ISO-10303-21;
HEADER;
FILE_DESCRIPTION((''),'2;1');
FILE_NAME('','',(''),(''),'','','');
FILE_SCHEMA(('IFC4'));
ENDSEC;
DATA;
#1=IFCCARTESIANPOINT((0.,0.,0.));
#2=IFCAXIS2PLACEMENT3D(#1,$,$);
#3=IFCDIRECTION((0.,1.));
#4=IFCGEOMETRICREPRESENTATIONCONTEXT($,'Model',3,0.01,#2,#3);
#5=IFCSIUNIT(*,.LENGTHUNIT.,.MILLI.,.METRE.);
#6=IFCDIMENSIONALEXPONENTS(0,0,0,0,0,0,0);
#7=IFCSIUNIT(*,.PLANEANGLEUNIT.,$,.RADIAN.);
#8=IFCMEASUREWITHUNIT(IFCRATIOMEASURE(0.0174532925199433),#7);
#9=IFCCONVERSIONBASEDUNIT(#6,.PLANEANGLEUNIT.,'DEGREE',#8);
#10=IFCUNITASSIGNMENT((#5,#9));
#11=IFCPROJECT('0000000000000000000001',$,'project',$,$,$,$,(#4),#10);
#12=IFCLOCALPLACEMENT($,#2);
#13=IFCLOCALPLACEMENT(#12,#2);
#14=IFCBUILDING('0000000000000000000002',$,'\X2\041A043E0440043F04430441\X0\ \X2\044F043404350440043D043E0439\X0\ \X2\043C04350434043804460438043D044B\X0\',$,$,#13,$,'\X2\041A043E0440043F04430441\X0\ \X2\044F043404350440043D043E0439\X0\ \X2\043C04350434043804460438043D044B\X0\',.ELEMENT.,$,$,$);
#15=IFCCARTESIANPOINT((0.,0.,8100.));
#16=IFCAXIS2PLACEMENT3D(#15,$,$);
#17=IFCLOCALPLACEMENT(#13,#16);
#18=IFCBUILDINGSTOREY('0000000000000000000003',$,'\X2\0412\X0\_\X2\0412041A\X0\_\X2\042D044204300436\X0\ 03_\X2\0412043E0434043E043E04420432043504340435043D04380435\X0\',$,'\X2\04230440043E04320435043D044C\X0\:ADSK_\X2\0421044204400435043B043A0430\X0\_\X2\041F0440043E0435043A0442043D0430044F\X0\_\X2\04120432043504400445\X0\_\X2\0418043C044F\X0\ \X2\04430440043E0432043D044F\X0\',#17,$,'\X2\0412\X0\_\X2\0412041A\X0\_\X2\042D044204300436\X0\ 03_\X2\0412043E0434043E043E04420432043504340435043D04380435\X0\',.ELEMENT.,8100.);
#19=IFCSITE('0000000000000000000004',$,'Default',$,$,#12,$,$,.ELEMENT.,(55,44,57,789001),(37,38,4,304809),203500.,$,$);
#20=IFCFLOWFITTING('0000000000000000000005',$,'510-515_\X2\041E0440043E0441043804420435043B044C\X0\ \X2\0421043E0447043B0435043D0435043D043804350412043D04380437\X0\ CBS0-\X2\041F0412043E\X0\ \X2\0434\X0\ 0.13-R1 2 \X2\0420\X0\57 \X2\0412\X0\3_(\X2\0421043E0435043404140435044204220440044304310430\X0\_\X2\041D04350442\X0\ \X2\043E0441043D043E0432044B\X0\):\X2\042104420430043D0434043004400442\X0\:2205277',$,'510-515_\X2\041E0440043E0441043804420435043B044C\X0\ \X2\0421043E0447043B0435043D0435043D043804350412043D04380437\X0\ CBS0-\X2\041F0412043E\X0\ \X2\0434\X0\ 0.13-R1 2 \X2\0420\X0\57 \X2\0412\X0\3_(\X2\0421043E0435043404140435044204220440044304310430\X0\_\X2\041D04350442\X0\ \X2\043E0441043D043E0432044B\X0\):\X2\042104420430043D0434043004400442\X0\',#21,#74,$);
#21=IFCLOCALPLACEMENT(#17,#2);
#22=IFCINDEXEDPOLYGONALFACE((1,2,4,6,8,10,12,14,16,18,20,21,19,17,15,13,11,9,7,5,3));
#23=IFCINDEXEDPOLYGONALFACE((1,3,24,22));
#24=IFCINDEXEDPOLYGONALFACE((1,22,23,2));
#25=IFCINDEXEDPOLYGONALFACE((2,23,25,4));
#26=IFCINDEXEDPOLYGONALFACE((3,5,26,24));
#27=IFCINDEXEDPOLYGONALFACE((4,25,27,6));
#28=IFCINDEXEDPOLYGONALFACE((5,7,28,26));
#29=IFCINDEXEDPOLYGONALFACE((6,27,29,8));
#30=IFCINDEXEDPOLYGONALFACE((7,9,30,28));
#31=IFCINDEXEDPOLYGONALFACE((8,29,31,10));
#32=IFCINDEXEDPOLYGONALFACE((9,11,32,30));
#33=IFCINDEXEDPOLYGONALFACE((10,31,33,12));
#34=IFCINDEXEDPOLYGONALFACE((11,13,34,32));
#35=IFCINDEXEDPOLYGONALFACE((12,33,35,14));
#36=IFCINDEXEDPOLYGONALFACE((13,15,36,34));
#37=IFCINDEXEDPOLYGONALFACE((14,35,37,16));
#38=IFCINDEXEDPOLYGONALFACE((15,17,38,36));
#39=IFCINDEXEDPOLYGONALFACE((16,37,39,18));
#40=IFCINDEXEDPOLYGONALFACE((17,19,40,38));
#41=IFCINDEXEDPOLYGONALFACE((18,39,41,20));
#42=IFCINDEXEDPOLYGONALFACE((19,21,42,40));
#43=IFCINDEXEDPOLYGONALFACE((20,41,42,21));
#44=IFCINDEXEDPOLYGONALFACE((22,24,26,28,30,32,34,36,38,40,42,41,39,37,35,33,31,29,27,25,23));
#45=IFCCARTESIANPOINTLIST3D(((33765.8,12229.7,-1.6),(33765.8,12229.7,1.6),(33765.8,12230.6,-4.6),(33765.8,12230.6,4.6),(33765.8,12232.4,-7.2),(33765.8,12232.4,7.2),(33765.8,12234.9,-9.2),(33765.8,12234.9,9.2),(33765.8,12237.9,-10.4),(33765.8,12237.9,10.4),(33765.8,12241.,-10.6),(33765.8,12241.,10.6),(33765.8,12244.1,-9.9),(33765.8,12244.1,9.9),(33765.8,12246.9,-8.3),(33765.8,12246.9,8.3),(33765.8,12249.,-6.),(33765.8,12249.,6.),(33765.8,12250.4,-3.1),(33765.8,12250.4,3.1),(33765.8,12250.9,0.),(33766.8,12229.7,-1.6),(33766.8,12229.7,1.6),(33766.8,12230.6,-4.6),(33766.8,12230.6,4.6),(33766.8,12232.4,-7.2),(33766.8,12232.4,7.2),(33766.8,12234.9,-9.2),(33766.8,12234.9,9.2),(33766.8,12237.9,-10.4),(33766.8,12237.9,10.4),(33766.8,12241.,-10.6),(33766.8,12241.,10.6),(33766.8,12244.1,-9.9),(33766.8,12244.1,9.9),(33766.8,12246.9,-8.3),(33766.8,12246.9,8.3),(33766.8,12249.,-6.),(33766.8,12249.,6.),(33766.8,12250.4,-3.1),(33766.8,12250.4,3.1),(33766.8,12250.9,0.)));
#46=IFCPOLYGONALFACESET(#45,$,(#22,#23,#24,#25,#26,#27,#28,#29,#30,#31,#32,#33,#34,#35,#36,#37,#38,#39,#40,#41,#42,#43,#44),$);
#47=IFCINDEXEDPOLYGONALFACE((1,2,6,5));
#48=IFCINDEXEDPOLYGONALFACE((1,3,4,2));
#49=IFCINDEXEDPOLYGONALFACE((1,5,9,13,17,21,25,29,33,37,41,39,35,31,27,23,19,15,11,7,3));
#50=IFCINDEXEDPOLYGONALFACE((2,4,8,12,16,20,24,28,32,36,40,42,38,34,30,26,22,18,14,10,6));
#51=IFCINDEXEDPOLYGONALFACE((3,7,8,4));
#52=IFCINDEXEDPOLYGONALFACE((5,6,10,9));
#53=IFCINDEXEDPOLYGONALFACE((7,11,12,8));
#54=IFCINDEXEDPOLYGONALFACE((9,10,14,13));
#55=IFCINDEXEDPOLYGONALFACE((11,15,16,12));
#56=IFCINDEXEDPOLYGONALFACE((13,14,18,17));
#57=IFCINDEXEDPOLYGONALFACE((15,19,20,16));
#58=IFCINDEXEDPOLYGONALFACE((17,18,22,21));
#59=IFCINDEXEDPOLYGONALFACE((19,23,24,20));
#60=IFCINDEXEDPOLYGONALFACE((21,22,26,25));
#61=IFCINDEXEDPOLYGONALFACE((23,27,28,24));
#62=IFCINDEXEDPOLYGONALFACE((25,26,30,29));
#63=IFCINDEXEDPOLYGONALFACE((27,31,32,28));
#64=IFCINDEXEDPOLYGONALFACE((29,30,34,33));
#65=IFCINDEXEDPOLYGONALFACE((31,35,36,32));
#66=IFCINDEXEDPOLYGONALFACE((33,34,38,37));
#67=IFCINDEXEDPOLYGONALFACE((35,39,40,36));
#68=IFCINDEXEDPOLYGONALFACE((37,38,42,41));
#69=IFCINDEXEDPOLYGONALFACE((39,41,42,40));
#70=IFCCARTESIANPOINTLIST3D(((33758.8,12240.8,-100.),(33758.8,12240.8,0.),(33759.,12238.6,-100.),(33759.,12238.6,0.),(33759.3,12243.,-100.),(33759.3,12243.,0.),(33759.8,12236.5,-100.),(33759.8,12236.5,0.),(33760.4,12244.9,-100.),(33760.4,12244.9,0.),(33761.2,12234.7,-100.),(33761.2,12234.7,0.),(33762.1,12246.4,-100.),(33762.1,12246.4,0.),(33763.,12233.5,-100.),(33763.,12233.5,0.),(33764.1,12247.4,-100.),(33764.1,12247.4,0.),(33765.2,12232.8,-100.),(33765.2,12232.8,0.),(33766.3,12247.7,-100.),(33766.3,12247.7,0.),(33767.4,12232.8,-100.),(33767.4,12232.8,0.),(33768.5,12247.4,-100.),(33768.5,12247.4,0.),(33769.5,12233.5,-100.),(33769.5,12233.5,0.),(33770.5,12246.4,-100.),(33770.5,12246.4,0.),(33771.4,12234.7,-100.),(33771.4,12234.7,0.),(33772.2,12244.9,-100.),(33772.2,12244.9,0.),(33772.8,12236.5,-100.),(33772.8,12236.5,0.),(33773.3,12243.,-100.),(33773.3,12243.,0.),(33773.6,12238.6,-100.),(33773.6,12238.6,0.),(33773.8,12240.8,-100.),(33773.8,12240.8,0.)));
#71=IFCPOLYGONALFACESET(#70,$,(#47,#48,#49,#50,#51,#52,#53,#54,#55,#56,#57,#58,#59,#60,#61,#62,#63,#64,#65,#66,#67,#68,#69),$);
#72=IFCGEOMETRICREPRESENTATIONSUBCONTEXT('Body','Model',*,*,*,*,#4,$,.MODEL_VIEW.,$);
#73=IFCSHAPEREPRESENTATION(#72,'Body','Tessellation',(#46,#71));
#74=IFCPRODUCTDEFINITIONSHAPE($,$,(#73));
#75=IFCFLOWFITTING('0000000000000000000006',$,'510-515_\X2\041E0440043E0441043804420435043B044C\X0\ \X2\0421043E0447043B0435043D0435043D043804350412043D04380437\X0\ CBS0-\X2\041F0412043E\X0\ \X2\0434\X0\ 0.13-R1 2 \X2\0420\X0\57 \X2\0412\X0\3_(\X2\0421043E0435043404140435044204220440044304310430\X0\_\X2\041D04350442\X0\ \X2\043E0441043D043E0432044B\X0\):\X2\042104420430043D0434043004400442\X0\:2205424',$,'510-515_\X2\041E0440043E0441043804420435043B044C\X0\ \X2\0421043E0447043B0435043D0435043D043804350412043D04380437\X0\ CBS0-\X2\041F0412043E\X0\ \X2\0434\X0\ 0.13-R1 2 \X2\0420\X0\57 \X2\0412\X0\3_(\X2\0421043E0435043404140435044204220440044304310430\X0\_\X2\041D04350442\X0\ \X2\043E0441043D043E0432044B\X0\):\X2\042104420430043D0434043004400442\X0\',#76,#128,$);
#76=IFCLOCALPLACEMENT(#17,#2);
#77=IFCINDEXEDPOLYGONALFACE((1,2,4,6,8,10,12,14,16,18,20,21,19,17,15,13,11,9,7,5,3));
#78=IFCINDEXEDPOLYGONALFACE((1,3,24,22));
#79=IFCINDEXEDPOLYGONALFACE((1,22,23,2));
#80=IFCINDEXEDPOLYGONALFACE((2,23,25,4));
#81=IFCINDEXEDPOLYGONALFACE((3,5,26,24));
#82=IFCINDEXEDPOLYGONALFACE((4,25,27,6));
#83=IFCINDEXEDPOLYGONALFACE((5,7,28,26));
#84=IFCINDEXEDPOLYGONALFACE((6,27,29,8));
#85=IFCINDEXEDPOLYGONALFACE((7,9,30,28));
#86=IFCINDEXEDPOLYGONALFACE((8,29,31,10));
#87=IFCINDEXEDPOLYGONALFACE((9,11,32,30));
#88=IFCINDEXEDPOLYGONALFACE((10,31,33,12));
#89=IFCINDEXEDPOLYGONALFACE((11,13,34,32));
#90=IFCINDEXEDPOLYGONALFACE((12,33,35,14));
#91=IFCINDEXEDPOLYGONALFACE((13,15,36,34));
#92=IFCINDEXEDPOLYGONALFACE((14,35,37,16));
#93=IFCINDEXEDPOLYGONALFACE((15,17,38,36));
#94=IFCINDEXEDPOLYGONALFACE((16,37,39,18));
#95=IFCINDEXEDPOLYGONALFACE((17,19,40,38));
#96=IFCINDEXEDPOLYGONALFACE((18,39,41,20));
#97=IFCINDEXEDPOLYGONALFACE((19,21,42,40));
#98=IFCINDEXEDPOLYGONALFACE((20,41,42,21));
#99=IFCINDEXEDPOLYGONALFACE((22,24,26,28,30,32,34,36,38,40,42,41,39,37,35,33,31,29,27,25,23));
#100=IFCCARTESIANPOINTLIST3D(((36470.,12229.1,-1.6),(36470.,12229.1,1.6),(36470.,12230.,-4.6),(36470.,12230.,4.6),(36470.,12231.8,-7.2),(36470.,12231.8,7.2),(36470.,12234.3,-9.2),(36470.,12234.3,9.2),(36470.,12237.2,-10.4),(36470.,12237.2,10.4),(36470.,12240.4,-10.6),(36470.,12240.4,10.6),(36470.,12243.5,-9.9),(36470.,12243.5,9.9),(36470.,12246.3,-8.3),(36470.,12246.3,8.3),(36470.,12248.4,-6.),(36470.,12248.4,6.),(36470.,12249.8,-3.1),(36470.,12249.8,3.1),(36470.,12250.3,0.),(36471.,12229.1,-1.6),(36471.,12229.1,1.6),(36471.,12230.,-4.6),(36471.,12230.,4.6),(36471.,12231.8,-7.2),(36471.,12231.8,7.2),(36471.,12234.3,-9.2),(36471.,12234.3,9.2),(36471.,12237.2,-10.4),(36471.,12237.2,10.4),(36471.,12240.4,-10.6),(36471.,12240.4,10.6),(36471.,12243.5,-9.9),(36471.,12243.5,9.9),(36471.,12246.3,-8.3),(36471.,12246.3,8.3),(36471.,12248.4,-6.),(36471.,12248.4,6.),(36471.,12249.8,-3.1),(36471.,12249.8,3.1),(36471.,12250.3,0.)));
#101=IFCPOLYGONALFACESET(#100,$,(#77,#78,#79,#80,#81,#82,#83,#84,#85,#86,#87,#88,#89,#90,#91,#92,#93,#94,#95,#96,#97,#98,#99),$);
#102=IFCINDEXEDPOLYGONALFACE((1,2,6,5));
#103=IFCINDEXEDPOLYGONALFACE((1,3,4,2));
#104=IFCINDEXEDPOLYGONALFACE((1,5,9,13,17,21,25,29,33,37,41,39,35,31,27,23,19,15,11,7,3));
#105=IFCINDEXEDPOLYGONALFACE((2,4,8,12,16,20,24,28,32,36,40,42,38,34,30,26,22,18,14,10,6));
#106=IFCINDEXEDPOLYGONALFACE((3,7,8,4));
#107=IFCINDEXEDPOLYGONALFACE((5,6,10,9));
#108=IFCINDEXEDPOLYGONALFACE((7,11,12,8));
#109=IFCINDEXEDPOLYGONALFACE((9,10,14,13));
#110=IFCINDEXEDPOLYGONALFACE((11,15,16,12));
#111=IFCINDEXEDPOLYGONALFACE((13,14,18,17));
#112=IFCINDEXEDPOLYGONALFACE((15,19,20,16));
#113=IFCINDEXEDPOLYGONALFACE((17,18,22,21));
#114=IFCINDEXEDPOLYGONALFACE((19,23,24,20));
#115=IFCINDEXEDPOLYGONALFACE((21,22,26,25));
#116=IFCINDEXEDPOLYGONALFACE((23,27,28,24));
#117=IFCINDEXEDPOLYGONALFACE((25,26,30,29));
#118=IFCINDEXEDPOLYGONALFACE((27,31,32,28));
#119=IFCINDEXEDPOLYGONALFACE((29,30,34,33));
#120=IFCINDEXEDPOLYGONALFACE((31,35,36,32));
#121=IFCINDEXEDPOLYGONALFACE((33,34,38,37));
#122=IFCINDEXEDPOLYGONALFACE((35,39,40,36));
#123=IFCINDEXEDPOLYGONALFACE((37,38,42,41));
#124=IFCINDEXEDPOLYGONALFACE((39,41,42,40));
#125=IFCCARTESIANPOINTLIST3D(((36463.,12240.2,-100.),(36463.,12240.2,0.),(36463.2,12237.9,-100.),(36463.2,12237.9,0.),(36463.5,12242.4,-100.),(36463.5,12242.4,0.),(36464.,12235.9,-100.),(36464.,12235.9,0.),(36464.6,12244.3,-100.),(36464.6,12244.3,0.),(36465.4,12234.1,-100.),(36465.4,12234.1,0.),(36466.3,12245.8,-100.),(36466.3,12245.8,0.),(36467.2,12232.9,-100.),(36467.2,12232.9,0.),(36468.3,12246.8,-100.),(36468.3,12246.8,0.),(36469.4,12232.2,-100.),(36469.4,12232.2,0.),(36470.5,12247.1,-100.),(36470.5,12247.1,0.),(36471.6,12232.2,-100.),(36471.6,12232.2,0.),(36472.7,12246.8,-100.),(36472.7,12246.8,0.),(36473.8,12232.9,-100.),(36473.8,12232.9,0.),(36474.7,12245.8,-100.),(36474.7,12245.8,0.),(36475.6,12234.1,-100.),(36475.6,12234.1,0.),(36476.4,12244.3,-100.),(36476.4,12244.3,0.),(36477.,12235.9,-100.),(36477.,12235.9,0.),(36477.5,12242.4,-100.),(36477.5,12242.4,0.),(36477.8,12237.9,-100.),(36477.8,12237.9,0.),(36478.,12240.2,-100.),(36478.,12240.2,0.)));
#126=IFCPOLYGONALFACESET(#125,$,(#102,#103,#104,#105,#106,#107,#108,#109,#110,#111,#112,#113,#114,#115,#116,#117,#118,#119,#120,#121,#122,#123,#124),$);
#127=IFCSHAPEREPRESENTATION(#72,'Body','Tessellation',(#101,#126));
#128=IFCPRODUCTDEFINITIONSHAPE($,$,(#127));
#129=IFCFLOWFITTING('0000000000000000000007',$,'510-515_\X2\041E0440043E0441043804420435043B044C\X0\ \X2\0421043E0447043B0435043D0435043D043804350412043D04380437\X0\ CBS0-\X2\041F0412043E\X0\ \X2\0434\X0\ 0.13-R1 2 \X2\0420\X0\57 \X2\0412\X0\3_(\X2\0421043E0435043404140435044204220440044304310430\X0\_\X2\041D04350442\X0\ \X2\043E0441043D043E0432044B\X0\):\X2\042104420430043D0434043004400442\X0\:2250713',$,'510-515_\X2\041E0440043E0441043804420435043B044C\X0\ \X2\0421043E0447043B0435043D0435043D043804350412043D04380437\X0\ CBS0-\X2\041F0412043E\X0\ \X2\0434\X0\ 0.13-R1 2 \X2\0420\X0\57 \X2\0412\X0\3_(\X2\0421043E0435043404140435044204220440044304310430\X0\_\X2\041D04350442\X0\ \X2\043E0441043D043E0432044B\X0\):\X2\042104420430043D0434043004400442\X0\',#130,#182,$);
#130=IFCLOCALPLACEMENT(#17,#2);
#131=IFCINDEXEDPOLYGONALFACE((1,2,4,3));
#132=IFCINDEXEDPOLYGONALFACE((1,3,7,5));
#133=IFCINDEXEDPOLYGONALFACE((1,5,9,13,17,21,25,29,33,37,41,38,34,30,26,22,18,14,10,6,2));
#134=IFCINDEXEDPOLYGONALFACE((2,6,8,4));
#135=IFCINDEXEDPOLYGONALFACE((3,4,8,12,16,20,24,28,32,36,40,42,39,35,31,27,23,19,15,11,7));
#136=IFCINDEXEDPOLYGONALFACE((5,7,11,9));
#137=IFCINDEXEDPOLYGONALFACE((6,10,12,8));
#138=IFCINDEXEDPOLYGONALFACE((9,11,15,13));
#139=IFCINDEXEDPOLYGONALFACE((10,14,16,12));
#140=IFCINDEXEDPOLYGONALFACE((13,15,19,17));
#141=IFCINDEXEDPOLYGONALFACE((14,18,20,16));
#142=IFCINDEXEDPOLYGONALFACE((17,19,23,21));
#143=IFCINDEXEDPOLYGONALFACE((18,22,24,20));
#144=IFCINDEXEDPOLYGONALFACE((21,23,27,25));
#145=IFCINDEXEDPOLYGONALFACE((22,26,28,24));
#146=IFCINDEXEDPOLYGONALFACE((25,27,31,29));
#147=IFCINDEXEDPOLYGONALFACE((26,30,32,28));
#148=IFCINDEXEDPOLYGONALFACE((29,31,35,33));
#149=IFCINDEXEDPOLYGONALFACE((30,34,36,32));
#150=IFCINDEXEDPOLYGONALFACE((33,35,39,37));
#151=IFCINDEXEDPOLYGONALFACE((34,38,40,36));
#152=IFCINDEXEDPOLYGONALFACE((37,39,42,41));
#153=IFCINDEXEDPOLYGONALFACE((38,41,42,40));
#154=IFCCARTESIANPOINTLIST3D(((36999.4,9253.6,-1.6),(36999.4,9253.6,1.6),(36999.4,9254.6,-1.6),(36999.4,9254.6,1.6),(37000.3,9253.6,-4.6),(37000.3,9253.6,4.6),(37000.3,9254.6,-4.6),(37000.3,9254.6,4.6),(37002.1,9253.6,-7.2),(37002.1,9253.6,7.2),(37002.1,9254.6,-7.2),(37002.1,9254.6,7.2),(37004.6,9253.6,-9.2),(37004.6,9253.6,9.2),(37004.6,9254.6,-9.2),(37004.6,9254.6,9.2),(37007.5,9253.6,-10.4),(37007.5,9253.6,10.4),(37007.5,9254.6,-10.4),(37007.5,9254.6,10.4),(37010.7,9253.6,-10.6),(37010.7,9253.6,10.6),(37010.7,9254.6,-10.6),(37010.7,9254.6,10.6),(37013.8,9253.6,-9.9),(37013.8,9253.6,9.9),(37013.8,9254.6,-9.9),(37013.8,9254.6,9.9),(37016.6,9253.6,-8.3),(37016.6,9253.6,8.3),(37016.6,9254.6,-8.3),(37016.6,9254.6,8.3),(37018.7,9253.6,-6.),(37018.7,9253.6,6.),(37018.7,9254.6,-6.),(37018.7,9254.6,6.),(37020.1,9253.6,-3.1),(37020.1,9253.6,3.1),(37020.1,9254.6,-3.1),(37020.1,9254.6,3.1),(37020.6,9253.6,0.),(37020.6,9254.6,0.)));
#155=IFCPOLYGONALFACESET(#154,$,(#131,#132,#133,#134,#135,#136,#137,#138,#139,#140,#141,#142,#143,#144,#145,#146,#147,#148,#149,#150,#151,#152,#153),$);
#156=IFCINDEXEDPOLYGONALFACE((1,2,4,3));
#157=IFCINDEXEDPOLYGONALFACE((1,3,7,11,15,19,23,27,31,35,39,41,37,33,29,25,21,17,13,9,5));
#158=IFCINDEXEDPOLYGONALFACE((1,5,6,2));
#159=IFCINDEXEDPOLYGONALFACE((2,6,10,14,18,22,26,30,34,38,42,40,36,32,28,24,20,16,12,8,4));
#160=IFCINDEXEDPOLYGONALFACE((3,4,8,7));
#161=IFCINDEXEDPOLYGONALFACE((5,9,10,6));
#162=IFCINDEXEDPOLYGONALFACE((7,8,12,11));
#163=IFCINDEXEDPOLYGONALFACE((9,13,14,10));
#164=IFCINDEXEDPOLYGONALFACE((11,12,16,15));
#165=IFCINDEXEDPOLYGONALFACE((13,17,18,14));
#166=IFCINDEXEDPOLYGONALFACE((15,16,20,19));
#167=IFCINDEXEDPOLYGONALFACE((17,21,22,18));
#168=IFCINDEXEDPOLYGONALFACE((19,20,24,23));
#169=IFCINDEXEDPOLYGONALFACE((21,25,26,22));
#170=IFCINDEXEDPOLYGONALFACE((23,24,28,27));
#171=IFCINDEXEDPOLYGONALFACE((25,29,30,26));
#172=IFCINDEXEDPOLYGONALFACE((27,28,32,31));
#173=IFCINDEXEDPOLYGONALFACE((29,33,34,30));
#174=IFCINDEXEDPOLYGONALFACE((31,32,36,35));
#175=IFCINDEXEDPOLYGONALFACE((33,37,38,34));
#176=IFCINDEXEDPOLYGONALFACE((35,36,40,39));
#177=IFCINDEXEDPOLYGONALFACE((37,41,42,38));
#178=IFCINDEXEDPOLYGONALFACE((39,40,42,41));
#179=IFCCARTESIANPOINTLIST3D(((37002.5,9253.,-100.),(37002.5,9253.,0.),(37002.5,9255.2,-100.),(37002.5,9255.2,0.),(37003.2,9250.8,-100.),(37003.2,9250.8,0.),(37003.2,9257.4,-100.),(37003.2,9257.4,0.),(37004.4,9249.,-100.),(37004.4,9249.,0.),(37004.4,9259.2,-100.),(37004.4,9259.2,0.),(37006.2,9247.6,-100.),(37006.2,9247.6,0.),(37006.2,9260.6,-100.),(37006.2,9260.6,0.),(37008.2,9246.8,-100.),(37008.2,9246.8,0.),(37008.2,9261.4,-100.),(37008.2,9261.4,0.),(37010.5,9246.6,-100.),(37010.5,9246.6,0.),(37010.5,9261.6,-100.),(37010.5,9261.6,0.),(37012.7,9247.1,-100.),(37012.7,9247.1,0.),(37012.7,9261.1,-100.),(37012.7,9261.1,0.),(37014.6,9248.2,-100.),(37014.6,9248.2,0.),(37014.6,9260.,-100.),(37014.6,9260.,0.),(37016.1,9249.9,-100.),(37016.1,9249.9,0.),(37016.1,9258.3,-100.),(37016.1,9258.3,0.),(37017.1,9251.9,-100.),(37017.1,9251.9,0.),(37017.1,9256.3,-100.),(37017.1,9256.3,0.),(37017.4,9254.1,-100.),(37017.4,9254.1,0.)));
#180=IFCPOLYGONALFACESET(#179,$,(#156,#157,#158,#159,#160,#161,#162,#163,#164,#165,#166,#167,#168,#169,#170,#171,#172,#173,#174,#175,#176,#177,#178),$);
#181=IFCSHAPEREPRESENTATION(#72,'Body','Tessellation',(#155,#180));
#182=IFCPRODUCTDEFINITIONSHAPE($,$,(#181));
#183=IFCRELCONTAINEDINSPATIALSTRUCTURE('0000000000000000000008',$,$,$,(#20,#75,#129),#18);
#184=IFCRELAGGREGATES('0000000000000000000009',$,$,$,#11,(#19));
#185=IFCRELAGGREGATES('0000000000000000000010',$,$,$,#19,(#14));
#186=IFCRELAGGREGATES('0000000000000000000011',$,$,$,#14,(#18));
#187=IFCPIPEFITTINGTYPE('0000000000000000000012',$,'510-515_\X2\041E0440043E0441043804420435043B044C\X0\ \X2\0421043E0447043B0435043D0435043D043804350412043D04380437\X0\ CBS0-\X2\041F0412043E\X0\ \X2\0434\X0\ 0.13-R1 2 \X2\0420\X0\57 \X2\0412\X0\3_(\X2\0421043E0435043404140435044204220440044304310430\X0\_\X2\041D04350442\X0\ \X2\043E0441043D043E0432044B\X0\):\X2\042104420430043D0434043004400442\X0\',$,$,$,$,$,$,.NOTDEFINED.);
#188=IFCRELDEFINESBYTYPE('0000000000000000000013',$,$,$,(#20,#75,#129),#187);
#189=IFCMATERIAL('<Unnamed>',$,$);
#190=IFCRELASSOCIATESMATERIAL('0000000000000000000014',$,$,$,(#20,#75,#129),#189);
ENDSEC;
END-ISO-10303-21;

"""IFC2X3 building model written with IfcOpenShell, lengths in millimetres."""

from ifc_helpers import new_model, entity, si_unit, converted_unit, direction, frame, origin, origin_2d_with_axis, place, context, subcontext, project, spatial, circle, extrude, source, transform, mapped, material, type_object, type_shapes, element, save


model = new_model("IFC2X3")

# Units and contexts
model_context = context("Model", 3, precision=0.01, world=origin(), true_north=direction((0.0, 1.0)))
body_context = subcontext(model_context, "Body", "Model", "MODEL_VIEW")
ifc_project = project(units=[si_unit("LENGTHUNIT", "METRE", prefix="MILLI"), converted_unit("PLANEANGLEUNIT", "DEGREE", entity("IfcRatioMeasure", 0.0174532925199433), si_unit("PLANEANGLEUNIT", "RADIAN"), dimensions=[0, 0, 0, 0, 0, 0, 0])], contexts=[model_context])

# Site, building, storey
site_placement = place(None, origin())
site = spatial("IfcSite", under=ifc_project, at=site_placement, Name="Default", CompositionType="ELEMENT", RefLatitude=(55, 44, 57, 789001), RefLongitude=(37, 38, 4, 304809), RefElevation=203500.0)
building_placement = place(site_placement, origin())
building = spatial("IfcBuilding", under=site, at=building_placement, Name="Корпус ядерной медицины", LongName="Корпус ядерной медицины", CompositionType="ELEMENT")
storey_placement = place(building_placement, frame((0.0, 0.0, 8100.0)))
storey = spatial("IfcBuildingStorey", under=building, at=storey_placement, Name="В_ВК_Этаж 03_Водоотведение", ObjectType="Уровень:ADSK_Стрелка_Проектная_Вверх_Имя уровня", LongName="В_ВК_Этаж 03_Водоотведение", CompositionType="ELEMENT", Elevation=8100.0)

# Flow fittings
ifc_material = material(Name="<Unnamed>")
pipe_fitting_type_1 = type_object("IfcPipeFittingType", Name="510-515_Ороситель СочленениеВниз CBS0-ПВо д 0.13-R1 2 Р57 В3_(СоедДетТруба_Нет основы):Стандарт", PredefinedType="NOTDEFINED")
shared_shape_1 = source(origin(), body_context, "Body", "SweptSolid", [
    extrude(circle(Radius=10.7, at=origin_2d_with_axis()), frame((-0.5, 0.0, 0.0), z_axis=(1.0, 0.0, 0.0), x_axis=(0.0, 1.0, 0.0)), (0.0, 0.0, 1.0), 1.0),
    extrude(circle(Radius=7.5, at=origin_2d_with_axis()), frame((0.0, 0.0, -100.0), z_axis=(0.0, 0.0, 1.0), x_axis=(0.0, 1.0, 0.0)), (0.0, 0.0, 1.0), 100.0),
])
type_shapes(pipe_fitting_type_1, [shared_shape_1])
for number, where, name in (
    (1, (33766.3, 12240.2, 0.0), "510-515_Ороситель СочленениеВниз CBS0-ПВо д 0.13-R1 2 Р57 В3_(СоедДетТруба_Нет основы):Стандарт:2205277"),
    (2, (36470.5, 12239.6, 0.0), "510-515_Ороситель СочленениеВниз CBS0-ПВо д 0.13-R1 2 Р57 В3_(СоедДетТруба_Нет основы):Стандарт:2205424"),
):
    element("IfcFlowFitting", number, at=place(storey_placement, frame(where)), inside=storey, type_object=pipe_fitting_type_1, material=ifc_material, Name=name, ObjectType="510-515_Ороситель СочленениеВниз CBS0-ПВо д 0.13-R1 2 Р57 В3_(СоедДетТруба_Нет основы):Стандарт", context=body_context, shape_type="MappedRepresentation", body=[
        mapped(shared_shape_1, transform((0.0, 0.0, 0.0), scale=1.0)),
    ])
for number, where, z_axis, x_axis, name in (
    (3, (37009.9, 9254.1, 0.0), (0.0, 0.0, 1.0), (0.0, -1.0, 0.0), "510-515_Ороситель СочленениеВниз CBS0-ПВо д 0.13-R1 2 Р57 В3_(СоедДетТруба_Нет основы):Стандарт:2250713"),
):
    element("IfcFlowFitting", number, at=place(storey_placement, frame(where, z_axis=z_axis, x_axis=x_axis)), inside=storey, type_object=pipe_fitting_type_1, material=ifc_material, Name=name, ObjectType="510-515_Ороситель СочленениеВниз CBS0-ПВо д 0.13-R1 2 Р57 В3_(СоедДетТруба_Нет основы):Стандарт", context=body_context, shape_type="MappedRepresentation", body=[
        mapped(shared_shape_1, transform((0.0, 0.0, 0.0), scale=1.0)),
    ])

save(model, "model.ifc")
